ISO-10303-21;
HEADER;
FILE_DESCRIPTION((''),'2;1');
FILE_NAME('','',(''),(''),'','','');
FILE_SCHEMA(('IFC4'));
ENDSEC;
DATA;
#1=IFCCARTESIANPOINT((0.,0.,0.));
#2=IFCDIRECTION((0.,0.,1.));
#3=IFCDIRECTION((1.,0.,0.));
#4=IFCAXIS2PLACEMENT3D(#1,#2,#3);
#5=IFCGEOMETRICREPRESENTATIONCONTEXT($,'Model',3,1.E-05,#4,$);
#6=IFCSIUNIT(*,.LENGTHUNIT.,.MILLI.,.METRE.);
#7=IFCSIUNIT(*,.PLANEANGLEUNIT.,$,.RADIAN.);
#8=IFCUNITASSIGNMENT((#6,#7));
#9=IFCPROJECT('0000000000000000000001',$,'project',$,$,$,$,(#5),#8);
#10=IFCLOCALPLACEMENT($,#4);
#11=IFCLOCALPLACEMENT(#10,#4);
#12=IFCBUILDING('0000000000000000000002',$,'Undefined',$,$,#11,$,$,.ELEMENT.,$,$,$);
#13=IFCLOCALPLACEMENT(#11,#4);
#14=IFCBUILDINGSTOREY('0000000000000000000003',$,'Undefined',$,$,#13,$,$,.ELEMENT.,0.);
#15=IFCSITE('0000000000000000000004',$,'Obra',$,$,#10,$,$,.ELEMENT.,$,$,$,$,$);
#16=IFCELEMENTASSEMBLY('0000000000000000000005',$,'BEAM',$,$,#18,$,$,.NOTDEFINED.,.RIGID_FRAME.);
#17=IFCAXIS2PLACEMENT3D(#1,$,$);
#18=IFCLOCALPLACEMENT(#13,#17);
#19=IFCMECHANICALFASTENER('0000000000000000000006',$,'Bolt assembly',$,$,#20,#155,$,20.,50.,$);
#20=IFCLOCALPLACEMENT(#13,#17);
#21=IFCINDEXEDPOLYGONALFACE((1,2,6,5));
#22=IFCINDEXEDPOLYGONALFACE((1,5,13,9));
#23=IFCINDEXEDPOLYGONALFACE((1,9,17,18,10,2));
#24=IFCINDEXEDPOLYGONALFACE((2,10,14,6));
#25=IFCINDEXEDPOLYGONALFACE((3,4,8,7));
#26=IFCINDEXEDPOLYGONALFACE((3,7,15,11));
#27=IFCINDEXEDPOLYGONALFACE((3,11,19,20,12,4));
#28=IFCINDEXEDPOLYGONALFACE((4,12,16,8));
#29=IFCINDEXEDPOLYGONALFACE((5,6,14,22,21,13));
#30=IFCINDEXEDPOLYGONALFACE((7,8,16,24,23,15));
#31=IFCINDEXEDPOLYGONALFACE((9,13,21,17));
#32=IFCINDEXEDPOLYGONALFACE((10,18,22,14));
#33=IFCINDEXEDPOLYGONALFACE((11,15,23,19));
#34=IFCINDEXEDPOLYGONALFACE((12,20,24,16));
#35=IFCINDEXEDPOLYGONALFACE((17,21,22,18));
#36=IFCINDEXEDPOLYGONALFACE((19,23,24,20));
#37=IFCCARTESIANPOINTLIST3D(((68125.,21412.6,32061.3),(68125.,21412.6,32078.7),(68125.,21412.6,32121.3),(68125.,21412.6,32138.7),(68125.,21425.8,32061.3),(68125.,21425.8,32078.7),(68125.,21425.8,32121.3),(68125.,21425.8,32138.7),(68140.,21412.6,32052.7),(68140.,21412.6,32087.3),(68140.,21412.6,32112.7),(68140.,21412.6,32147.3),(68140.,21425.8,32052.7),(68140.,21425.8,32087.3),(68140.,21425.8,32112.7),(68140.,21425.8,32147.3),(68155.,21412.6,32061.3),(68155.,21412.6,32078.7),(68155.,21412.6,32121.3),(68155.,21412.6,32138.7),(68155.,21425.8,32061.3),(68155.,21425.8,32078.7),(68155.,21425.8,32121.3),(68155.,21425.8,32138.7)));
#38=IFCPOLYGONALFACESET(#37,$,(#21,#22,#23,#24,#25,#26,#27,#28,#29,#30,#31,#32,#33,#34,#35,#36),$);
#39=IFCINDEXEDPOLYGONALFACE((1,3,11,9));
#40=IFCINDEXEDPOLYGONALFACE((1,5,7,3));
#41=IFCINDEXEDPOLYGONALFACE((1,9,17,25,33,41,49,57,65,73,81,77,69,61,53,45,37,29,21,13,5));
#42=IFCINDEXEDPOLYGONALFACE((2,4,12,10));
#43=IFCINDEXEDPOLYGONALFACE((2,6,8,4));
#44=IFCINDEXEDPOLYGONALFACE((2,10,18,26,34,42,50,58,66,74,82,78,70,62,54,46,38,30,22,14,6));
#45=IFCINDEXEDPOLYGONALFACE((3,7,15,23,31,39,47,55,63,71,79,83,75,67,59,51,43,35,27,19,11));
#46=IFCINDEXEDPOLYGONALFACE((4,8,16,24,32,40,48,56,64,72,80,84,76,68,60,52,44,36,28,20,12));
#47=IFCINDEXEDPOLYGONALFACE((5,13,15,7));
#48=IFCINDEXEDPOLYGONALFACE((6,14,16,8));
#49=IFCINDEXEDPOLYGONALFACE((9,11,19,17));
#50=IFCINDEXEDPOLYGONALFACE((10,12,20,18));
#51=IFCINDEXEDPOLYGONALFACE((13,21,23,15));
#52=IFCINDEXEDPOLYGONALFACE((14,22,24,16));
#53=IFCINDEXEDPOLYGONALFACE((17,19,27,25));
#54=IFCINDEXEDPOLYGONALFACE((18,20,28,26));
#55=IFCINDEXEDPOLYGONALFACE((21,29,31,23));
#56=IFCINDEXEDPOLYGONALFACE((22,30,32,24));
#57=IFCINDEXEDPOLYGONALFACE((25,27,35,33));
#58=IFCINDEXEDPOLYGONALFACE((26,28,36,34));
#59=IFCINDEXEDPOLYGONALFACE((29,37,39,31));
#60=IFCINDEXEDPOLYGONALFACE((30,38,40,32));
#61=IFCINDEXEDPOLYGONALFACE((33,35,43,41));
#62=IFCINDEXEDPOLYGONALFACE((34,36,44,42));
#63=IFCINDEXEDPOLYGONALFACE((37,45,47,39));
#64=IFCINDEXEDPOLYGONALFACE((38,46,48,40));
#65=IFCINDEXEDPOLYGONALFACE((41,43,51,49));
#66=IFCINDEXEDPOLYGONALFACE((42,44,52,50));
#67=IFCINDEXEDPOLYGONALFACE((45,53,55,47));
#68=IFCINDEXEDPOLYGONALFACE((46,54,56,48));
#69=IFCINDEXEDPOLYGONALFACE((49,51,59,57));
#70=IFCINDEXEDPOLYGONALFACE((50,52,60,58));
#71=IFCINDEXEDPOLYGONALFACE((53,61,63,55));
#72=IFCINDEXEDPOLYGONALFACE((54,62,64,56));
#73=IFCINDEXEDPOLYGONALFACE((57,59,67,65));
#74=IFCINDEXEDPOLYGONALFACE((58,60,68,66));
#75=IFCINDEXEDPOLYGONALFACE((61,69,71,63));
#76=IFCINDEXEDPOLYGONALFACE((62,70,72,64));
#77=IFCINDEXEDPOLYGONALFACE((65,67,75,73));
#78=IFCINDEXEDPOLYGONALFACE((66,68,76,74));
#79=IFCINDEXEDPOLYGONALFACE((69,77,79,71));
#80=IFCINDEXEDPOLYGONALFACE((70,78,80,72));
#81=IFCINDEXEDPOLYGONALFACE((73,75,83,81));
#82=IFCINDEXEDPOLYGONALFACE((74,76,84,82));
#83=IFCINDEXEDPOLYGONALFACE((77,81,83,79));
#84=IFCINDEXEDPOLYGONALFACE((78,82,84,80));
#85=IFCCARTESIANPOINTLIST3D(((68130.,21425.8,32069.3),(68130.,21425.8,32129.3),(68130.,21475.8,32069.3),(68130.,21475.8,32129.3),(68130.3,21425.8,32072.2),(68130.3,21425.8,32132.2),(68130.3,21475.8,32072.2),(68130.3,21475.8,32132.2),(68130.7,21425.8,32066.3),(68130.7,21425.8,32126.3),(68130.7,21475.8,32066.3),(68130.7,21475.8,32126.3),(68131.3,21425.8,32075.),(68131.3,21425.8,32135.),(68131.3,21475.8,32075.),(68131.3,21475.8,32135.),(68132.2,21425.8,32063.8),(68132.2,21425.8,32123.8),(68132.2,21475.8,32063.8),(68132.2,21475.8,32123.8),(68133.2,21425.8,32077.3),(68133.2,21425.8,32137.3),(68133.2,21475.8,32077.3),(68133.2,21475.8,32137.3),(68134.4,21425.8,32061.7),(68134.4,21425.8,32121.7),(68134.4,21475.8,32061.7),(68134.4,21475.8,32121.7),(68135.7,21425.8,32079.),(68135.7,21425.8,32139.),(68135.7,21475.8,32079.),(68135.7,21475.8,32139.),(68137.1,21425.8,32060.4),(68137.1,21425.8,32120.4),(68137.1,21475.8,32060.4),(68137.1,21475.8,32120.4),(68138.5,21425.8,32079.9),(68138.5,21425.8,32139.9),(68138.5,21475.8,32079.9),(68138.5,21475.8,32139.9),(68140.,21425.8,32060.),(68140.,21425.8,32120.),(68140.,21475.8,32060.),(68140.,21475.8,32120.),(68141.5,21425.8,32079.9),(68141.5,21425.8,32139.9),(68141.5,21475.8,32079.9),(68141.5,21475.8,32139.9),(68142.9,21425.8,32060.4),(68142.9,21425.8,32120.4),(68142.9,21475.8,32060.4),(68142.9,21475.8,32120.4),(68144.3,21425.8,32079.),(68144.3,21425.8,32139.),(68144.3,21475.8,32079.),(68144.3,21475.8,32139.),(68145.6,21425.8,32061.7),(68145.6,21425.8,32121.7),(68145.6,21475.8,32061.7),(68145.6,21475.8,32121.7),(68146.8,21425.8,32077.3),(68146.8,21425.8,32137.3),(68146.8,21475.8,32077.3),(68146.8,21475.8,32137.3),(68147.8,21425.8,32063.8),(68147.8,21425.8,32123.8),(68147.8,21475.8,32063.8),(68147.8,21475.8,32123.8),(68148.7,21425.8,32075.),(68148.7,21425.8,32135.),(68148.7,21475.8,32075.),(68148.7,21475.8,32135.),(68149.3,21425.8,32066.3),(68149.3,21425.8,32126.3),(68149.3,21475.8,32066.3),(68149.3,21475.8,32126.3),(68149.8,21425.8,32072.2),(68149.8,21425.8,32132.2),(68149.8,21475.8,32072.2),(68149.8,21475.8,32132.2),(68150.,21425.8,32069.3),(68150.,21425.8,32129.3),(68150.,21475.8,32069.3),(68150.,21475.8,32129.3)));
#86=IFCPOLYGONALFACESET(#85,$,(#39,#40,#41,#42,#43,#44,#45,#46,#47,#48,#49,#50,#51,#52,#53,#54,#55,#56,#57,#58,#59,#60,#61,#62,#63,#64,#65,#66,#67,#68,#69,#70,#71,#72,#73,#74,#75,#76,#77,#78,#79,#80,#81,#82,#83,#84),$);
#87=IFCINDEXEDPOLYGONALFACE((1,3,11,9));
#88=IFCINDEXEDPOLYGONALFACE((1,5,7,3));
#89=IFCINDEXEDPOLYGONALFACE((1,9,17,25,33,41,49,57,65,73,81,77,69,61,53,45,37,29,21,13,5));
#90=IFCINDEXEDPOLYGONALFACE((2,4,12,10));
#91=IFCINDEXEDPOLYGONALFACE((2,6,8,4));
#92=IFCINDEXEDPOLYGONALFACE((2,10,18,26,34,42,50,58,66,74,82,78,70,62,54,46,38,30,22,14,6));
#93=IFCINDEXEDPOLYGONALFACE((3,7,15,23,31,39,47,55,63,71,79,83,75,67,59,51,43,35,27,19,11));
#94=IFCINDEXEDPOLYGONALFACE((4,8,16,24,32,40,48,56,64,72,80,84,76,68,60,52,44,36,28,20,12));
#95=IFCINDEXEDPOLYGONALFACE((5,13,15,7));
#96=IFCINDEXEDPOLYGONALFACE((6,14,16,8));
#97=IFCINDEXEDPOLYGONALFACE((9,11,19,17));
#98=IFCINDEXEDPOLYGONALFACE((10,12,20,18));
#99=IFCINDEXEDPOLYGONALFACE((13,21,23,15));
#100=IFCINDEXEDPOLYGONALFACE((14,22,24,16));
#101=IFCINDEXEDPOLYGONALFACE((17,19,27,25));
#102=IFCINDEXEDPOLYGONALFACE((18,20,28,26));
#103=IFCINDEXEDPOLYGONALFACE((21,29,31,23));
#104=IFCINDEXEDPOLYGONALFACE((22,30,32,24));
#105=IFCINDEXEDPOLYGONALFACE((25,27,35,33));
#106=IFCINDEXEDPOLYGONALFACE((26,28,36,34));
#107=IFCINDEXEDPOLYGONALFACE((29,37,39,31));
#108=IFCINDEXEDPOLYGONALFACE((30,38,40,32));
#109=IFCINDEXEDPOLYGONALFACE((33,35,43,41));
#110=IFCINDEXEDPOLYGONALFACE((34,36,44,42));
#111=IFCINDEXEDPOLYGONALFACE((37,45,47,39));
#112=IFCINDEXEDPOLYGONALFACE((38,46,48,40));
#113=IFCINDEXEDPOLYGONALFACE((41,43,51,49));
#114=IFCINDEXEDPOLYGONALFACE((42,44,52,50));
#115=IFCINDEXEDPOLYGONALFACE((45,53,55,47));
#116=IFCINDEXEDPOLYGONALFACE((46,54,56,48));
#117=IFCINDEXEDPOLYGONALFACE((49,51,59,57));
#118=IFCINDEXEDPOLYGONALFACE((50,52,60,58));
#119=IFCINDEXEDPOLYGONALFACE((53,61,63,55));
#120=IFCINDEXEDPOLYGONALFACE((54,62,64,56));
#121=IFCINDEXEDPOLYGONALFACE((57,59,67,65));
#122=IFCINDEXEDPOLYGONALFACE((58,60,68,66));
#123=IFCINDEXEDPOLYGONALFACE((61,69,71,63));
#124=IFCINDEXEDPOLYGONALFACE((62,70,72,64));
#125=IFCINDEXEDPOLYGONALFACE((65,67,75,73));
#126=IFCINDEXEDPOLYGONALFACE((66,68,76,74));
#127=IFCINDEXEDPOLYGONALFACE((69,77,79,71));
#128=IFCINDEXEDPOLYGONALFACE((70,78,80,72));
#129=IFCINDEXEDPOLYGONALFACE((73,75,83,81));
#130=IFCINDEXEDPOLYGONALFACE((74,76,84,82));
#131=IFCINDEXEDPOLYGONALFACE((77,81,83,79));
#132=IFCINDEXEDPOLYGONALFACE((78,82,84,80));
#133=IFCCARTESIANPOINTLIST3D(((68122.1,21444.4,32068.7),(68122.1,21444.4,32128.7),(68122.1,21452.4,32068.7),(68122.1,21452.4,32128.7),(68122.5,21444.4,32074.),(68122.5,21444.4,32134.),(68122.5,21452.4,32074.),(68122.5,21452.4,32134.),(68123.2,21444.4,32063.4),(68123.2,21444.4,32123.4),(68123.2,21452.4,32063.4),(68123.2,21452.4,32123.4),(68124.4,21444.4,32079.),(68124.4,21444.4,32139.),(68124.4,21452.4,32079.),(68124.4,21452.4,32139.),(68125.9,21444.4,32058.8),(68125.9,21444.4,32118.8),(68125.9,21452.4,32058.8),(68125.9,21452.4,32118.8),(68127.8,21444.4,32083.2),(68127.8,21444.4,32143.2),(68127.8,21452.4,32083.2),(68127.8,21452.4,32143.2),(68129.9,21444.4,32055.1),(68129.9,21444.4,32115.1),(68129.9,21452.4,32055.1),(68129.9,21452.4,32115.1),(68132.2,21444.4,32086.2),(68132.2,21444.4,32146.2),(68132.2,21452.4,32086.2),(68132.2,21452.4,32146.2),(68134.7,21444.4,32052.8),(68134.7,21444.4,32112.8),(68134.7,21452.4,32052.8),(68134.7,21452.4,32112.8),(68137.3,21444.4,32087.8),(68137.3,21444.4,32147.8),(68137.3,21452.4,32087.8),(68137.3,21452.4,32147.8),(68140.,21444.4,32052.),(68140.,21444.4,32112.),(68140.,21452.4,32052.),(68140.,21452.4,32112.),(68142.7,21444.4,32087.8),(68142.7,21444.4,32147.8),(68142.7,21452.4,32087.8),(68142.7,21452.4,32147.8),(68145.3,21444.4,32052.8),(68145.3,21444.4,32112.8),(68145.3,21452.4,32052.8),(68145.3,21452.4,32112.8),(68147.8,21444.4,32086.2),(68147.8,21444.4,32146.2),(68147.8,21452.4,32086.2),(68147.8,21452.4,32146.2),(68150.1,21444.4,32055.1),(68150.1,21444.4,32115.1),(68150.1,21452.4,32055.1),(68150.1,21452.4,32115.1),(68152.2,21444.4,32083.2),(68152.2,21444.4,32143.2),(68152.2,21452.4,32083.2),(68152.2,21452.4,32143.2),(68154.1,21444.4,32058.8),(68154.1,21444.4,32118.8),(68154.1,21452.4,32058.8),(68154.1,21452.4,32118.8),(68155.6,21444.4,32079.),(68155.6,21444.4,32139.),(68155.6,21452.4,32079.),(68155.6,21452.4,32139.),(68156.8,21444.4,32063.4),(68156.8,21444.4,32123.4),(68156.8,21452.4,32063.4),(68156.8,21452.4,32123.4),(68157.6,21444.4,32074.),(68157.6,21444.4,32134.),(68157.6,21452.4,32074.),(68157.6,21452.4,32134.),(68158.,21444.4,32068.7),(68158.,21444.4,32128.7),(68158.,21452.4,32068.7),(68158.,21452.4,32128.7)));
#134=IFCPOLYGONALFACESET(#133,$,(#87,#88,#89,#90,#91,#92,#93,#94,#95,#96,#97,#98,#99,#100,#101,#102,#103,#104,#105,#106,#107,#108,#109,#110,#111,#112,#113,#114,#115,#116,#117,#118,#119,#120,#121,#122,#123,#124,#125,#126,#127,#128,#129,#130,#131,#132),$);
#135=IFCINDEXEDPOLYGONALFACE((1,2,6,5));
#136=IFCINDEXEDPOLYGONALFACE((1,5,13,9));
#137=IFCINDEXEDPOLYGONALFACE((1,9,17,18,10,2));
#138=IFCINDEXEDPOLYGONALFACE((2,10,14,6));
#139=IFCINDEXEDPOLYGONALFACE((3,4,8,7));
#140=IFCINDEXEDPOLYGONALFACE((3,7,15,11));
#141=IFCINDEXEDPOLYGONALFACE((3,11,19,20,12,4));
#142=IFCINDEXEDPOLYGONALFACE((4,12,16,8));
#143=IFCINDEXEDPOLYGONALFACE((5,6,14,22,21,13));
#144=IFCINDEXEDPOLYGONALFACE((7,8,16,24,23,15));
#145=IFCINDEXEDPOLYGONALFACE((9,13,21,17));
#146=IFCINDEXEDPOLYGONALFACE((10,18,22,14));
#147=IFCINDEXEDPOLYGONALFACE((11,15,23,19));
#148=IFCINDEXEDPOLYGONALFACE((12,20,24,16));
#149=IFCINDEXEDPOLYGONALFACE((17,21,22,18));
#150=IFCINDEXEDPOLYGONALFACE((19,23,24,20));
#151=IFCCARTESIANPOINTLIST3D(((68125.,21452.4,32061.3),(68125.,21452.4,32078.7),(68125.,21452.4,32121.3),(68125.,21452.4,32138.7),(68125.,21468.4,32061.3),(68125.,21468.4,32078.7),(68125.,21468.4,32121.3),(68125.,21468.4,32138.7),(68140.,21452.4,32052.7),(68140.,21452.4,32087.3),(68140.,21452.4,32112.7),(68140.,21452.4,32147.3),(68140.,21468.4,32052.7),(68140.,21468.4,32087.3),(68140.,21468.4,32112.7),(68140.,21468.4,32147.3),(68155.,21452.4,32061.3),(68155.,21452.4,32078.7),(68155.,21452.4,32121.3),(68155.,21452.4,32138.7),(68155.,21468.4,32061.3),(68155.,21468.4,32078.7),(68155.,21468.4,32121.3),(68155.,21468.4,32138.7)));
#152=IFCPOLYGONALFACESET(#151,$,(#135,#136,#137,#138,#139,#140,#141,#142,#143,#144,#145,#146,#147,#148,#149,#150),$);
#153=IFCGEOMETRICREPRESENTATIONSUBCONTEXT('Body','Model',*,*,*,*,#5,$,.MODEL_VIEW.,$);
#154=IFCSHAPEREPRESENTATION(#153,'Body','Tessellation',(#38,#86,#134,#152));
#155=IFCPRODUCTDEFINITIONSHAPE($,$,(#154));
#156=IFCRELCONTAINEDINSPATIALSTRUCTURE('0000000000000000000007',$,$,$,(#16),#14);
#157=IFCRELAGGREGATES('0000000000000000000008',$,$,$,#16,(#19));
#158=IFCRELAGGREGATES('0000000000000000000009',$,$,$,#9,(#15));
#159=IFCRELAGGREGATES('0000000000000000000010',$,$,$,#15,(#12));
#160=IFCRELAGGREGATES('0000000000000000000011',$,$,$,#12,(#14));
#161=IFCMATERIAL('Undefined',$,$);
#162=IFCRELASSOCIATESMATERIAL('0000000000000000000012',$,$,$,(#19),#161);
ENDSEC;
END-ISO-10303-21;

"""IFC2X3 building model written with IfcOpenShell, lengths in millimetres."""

from ifc_helpers import new_model, si_unit, frame, origin_with_axes, origin_2d_with_axis, place, context, subcontext, project, spatial, polyline, circle, outline, extrude, source, transform, mapped, material, element, aggregate, save


model = new_model("IFC2X3")

# Units and contexts
model_context = context("Model", 3, precision=1e-05, world=origin_with_axes())
body_context = subcontext(model_context, "Body", "Model", "MODEL_VIEW")
ifc_project = project(units=[si_unit("LENGTHUNIT", "METRE", prefix="MILLI"), si_unit("PLANEANGLEUNIT", "RADIAN")], contexts=[model_context])

# Site, building, storey
site_placement = place(None, origin_with_axes())
site = spatial("IfcSite", under=ifc_project, at=site_placement, Name="Obra", CompositionType="ELEMENT")
building_placement = place(site_placement, origin_with_axes())
building = spatial("IfcBuilding", under=site, at=building_placement, Name="Undefined", CompositionType="ELEMENT")
storey_placement = place(building_placement, origin_with_axes())
storey = spatial("IfcBuildingStorey", under=building, at=storey_placement, Name="Undefined", CompositionType="ELEMENT", Elevation=0.0)

# Element assembly
assembly_1_placement = place(storey_placement, origin_with_axes())
assembly_1 = element("IfcElementAssembly", 1, at=assembly_1_placement, inside=storey, Name="BEAM", AssemblyPlace="NOTDEFINED", PredefinedType="RIGID_FRAME")

# Shared definitions
ifc_material_1 = material(Name="Undefined")

# Mechanical fastener
shared_shape_1 = source(origin_with_axes(), body_context, "Body", "SweptSolid", [
    extrude(outline(polyline([(17.3, 0.0), (8.7, 15.0), (-8.7, 15.0), (-17.3, 0.0), (-8.7, -15.0), (8.7, -15.0), (17.3, 0.0)])), frame((0.0, -27.5, 0.0), z_axis=(0.0, 1.0, 0.0), x_axis=(1.0, 0.0, 0.0)), (0.0, 0.0, 1.0), 13.2),
    extrude(circle(Radius=10.0, at=origin_2d_with_axis()), frame((0.0, -14.3, 0.0), z_axis=(0.0, 1.0, 0.0), x_axis=(1.0, 0.0, 0.0)), (0.0, 0.0, 1.0), 50.0),
    extrude(circle(Radius=18.0, at=origin_2d_with_axis()), frame((0.0, 4.3, 0.0), z_axis=(0.0, 1.0, 0.0), x_axis=(1.0, 0.0, 0.0)), (0.0, 0.0, 1.0), 8.0),
    extrude(outline(polyline([(17.3, 0.0), (8.7, 15.0), (-8.7, 15.0), (-17.3, 0.0), (-8.7, -15.0), (8.7, -15.0), (17.3, 0.0)])), frame((0.0, 12.3, 0.0), z_axis=(0.0, 1.0, 0.0), x_axis=(1.0, 0.0, 0.0)), (0.0, 0.0, 1.0), 16.0),
])
mechanical_fastener_1_placement = place(assembly_1_placement, frame((68100.0, 21440.1, 32170.0), z_axis=(1.0, 0.0, 0.0), x_axis=(0.0, 0.0, -1.0)))
mechanical_fastener_1 = element("IfcMechanicalFastener", 2, at=mechanical_fastener_1_placement, material=ifc_material_1, Name="Bolt assembly", NominalDiameter=20.0, NominalLength=50.0, context=body_context, shape_type="MappedRepresentation", body=[
    mapped(shared_shape_1, transform((40.0, 0.0, 40.0))),
    mapped(shared_shape_1, transform((100.0, 0.0, 40.0))),
])

aggregate(assembly_1, [mechanical_fastener_1])

save(model, "model.ifc")
